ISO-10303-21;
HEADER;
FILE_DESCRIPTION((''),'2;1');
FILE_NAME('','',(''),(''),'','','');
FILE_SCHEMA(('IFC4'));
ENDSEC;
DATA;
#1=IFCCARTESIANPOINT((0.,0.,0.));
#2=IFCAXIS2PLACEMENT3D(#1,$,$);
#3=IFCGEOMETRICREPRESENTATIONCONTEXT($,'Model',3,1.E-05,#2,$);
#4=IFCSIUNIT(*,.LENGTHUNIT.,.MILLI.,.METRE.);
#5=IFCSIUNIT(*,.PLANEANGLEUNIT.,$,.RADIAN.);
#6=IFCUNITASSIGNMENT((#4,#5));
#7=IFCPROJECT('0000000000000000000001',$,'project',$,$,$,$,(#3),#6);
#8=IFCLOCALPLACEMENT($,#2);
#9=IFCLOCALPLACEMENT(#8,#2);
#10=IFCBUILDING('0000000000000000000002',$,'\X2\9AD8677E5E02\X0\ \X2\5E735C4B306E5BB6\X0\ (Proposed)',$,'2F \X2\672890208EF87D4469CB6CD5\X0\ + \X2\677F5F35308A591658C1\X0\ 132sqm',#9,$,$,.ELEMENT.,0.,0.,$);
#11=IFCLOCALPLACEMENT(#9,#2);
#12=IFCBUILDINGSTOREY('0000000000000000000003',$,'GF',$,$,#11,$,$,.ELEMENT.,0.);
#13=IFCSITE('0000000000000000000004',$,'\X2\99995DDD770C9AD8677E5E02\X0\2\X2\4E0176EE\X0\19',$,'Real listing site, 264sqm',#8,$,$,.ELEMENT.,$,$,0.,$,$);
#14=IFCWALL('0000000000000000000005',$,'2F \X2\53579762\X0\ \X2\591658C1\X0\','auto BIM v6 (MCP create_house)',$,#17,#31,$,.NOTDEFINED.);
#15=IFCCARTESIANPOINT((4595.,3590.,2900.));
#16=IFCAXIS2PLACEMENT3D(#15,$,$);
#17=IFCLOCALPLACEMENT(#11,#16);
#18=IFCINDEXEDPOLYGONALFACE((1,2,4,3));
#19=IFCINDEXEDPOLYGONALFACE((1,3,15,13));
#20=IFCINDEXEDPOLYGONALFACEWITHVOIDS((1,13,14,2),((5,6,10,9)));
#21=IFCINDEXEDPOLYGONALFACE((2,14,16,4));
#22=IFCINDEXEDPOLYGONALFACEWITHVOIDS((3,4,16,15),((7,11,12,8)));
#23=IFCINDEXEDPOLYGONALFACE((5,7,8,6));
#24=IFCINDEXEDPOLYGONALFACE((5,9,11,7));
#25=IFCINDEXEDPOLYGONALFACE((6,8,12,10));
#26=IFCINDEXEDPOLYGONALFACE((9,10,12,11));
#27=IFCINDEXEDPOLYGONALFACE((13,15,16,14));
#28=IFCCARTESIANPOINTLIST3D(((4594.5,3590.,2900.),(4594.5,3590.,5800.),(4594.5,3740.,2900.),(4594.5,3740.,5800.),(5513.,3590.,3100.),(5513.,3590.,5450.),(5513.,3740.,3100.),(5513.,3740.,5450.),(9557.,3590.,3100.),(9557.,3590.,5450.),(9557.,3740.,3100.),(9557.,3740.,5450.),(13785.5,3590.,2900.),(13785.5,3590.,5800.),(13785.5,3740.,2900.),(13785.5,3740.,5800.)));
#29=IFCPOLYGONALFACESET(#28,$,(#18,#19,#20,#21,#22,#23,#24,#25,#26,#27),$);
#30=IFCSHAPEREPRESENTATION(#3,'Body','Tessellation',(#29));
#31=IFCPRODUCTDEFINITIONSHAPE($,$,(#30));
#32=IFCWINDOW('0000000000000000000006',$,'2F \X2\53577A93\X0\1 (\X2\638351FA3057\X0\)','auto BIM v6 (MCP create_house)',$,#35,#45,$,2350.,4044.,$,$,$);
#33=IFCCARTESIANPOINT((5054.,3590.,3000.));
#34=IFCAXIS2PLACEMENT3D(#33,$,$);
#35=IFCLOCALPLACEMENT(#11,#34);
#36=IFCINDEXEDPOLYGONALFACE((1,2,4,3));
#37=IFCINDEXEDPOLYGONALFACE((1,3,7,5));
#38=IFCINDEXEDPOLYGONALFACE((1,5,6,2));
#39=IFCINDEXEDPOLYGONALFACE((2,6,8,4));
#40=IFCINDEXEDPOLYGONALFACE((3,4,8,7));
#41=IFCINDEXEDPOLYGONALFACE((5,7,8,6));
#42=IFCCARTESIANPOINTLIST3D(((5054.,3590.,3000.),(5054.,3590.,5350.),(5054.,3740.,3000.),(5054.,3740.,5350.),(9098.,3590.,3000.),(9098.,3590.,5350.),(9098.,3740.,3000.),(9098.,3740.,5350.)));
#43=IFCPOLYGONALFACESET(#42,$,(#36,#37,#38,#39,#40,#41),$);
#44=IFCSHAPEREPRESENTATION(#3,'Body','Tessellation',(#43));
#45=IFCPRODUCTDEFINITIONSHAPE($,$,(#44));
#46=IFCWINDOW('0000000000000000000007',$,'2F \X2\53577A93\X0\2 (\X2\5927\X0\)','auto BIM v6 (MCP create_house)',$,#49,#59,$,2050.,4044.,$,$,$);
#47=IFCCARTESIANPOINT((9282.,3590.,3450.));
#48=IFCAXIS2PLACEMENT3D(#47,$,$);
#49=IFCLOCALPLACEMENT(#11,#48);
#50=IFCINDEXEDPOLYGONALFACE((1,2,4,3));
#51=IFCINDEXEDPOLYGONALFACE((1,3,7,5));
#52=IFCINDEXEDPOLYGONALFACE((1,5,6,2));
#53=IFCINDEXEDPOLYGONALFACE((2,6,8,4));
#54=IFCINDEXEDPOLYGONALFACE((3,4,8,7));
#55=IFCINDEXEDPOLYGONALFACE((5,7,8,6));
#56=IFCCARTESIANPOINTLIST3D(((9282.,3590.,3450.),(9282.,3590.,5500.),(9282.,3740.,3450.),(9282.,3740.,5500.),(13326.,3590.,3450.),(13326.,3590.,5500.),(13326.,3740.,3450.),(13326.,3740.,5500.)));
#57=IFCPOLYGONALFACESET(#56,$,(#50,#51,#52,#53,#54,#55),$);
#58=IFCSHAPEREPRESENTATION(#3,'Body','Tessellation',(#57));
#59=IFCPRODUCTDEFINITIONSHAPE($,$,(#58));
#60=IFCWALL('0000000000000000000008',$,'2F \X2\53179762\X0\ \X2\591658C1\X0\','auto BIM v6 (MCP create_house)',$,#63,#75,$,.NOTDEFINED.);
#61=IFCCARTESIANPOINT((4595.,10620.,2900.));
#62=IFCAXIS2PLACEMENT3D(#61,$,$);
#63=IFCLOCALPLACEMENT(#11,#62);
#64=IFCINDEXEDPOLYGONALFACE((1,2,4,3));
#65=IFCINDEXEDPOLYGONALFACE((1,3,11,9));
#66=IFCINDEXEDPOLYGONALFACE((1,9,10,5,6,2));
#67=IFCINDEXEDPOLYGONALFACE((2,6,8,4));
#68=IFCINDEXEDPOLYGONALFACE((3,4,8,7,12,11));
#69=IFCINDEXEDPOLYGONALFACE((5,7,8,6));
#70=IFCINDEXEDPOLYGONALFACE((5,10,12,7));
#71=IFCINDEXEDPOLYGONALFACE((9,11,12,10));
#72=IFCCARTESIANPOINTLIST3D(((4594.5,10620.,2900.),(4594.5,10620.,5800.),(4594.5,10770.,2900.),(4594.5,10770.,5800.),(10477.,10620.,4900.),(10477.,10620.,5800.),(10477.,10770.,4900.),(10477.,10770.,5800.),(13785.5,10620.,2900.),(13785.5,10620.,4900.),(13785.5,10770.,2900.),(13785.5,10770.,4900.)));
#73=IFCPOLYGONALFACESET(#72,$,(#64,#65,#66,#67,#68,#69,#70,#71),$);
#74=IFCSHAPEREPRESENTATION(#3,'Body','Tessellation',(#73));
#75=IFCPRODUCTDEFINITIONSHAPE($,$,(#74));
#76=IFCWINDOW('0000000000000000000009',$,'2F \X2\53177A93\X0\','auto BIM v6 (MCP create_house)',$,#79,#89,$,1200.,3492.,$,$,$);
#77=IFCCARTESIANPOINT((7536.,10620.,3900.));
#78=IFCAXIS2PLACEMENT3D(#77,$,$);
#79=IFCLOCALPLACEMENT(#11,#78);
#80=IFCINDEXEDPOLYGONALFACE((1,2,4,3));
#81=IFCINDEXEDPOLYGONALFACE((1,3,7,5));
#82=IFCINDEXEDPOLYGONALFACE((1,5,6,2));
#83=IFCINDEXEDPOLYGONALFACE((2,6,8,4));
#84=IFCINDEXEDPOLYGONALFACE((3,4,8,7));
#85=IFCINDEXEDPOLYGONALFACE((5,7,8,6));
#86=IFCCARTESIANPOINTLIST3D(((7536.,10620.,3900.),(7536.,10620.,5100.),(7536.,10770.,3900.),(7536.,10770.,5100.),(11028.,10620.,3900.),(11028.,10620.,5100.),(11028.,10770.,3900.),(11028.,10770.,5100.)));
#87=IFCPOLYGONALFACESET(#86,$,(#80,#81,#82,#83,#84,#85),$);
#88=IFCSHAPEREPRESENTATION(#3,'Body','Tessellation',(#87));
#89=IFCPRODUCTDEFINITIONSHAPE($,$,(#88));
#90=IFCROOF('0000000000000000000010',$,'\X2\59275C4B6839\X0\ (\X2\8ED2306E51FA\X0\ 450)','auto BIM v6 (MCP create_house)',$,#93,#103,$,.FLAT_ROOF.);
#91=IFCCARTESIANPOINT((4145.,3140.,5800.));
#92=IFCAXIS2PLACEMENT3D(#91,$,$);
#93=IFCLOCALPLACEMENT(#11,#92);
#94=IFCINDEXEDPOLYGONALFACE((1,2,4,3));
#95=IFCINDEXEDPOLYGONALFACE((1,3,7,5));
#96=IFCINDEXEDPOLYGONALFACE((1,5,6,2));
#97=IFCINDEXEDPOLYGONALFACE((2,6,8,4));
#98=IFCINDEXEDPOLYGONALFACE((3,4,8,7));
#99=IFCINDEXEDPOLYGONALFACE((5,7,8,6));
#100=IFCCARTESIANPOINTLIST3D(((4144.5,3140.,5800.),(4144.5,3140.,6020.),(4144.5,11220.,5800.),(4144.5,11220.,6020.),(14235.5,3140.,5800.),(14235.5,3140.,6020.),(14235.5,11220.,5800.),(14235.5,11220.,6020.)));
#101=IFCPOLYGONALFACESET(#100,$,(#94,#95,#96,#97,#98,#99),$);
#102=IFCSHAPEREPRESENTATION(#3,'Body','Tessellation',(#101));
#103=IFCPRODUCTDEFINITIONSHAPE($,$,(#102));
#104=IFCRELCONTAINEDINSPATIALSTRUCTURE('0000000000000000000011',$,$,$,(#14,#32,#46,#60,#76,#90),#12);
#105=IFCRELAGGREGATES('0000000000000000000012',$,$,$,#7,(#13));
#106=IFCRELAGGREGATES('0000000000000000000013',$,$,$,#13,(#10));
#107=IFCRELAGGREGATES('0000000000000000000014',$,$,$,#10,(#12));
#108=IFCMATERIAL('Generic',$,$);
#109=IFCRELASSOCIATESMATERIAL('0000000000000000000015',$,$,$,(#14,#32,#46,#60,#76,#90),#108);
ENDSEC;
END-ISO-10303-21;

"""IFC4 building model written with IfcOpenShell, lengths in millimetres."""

from ifc_helpers import new_model, si_unit, frame, frame_2d, origin, place, context, project, spatial, rectangle, extrude, material, element, fill, save


model = new_model("IFC4")

# Units and contexts
model_context = context("Model", 3, precision=1e-05, world=origin())
ifc_project = project(units=[si_unit("LENGTHUNIT", "METRE", prefix="MILLI"), si_unit("PLANEANGLEUNIT", "RADIAN")], contexts=[model_context])

# Site, building, storey
site_placement = place(None, origin())
site = spatial("IfcSite", under=ifc_project, at=site_placement, Name="香川県高松市2丁目19", ObjectType="Real listing site, 264sqm", CompositionType="ELEMENT", RefElevation=0.0)
building_placement = place(site_placement, origin())
building = spatial("IfcBuilding", under=site, at=building_placement, Name="高松市 平屋の家 (Proposed)", ObjectType="2F 木造軸組構法 + 板張り外壁 132sqm", CompositionType="ELEMENT", ElevationOfRefHeight=0.0, ElevationOfTerrain=0.0)
storey_placement = place(building_placement, origin())
storey = spatial("IfcBuildingStorey", under=building, at=storey_placement, Name="GF", CompositionType="ELEMENT", Elevation=0.0)

# Shared definitions
ifc_material = material(Name="Generic")

# Wall, openings, windows
wall_1_placement = place(storey_placement, frame((4595.0, 3590.0, 2900.0)))
wall_1 = element("IfcWall", 1, at=wall_1_placement, inside=storey, material=ifc_material, Name="2F 南面 外壁", Description="auto BIM v6 (MCP create_house)", PredefinedType="NOTDEFINED", context=model_context, shape_type="SweptSolid", body=[
    extrude(rectangle(XDim=9191.0, YDim=150.0, at=frame_2d((4595.0, 75.0))), frame((4595.0, 3590.0, 2900.0)), (0.0, 0.0, 1.0), 2900.0),
])
opening_1_placement = place(storey_placement, frame((5054.0, 3590.0, 3000.0)))
opening_1 = element("IfcOpeningElement", 2, at=opening_1_placement, cuts=wall_1, PredefinedType="NOTDEFINED", context=model_context, shape_type="SweptSolid", body=[
    extrude(rectangle(XDim=4044.0, YDim=150.0, at=frame_2d((2022.0, 75.0))), frame((5054.0, 3590.0, 3000.0)), (0.0, 0.0, 1.0), 2350.0),
])
opening_2_placement = place(storey_placement, frame((9282.0, 3590.0, 3450.0)))
opening_2 = element("IfcOpeningElement", 3, at=opening_2_placement, cuts=wall_1, PredefinedType="NOTDEFINED", context=model_context, shape_type="SweptSolid", body=[
    extrude(rectangle(XDim=4044.0, YDim=150.0, at=frame_2d((2022.0, 75.0))), frame((9282.0, 3590.0, 3450.0)), (0.0, 0.0, 1.0), 2050.0),
])
window_1_placement = place(storey_placement, frame((5054.0, 3590.0, 3000.0)))
window_1 = element("IfcWindow", 4, at=window_1_placement, inside=storey, material=ifc_material, Name="2F 南窓1 (掃出し)", Description="auto BIM v6 (MCP create_house)", OverallHeight=2350.0, OverallWidth=4044.0, context=model_context, shape_type="SweptSolid", body=[
    extrude(rectangle(XDim=4044.0, YDim=150.0, at=frame_2d((2022.0, 75.0))), frame((5054.0, 3590.0, 3000.0)), (0.0, 0.0, 1.0), 2350.0),
])
fill(opening_1, window_1)
window_2_placement = place(storey_placement, frame((9282.0, 3590.0, 3450.0)))
window_2 = element("IfcWindow", 5, at=window_2_placement, inside=storey, material=ifc_material, Name="2F 南窓2 (大)", Description="auto BIM v6 (MCP create_house)", OverallHeight=2050.0, OverallWidth=4044.0, context=model_context, shape_type="SweptSolid", body=[
    extrude(rectangle(XDim=4044.0, YDim=150.0, at=frame_2d((2022.0, 75.0))), frame((9282.0, 3590.0, 3450.0)), (0.0, 0.0, 1.0), 2050.0),
])
fill(opening_2, window_2)

# Wall, opening, window
wall_2_placement = place(storey_placement, frame((4595.0, 10620.0, 2900.0)))
wall_2 = element("IfcWall", 6, at=wall_2_placement, inside=storey, material=ifc_material, Name="2F 北面 外壁", Description="auto BIM v6 (MCP create_house)", PredefinedType="NOTDEFINED", context=model_context, shape_type="SweptSolid", body=[
    extrude(rectangle(XDim=9191.0, YDim=150.0, at=frame_2d((4595.0, 75.0))), frame((4595.0, 10620.0, 2900.0)), (0.0, 0.0, 1.0), 2900.0),
])
opening_3_placement = place(storey_placement, frame((7536.0, 10620.0, 3900.0)))
opening_3 = element("IfcOpeningElement", 7, at=opening_3_placement, cuts=wall_2, PredefinedType="NOTDEFINED", context=model_context, shape_type="SweptSolid", body=[
    extrude(rectangle(XDim=3492.0, YDim=150.0, at=frame_2d((1746.0, 75.0))), frame((7536.0, 10620.0, 3900.0)), (0.0, 0.0, 1.0), 1200.0),
])
window_3_placement = place(storey_placement, frame((7536.0, 10620.0, 3900.0)))
window_3 = element("IfcWindow", 8, at=window_3_placement, inside=storey, material=ifc_material, Name="2F 北窓", Description="auto BIM v6 (MCP create_house)", OverallHeight=1200.0, OverallWidth=3492.0, context=model_context, shape_type="SweptSolid", body=[
    extrude(rectangle(XDim=3492.0, YDim=150.0, at=frame_2d((1746.0, 75.0))), frame((7536.0, 10620.0, 3900.0)), (0.0, 0.0, 1.0), 1200.0),
])
fill(opening_3, window_3)

# Roof
roof_placement = place(storey_placement, frame((4145.0, 3140.0, 5800.0)))
element("IfcRoof", 9, at=roof_placement, inside=storey, material=ifc_material, Name="大屋根 (軒の出 450)", Description="auto BIM v6 (MCP create_house)", PredefinedType="FLAT_ROOF", context=model_context, shape_type="SweptSolid", body=[
    extrude(rectangle(XDim=10091.0, YDim=8080.0, at=frame_2d((5045.0, 4040.0))), frame((4145.0, 3140.0, 5800.0)), (0.0, 0.0, 1.0), 220.0),
])

save(model, "model.ifc")
